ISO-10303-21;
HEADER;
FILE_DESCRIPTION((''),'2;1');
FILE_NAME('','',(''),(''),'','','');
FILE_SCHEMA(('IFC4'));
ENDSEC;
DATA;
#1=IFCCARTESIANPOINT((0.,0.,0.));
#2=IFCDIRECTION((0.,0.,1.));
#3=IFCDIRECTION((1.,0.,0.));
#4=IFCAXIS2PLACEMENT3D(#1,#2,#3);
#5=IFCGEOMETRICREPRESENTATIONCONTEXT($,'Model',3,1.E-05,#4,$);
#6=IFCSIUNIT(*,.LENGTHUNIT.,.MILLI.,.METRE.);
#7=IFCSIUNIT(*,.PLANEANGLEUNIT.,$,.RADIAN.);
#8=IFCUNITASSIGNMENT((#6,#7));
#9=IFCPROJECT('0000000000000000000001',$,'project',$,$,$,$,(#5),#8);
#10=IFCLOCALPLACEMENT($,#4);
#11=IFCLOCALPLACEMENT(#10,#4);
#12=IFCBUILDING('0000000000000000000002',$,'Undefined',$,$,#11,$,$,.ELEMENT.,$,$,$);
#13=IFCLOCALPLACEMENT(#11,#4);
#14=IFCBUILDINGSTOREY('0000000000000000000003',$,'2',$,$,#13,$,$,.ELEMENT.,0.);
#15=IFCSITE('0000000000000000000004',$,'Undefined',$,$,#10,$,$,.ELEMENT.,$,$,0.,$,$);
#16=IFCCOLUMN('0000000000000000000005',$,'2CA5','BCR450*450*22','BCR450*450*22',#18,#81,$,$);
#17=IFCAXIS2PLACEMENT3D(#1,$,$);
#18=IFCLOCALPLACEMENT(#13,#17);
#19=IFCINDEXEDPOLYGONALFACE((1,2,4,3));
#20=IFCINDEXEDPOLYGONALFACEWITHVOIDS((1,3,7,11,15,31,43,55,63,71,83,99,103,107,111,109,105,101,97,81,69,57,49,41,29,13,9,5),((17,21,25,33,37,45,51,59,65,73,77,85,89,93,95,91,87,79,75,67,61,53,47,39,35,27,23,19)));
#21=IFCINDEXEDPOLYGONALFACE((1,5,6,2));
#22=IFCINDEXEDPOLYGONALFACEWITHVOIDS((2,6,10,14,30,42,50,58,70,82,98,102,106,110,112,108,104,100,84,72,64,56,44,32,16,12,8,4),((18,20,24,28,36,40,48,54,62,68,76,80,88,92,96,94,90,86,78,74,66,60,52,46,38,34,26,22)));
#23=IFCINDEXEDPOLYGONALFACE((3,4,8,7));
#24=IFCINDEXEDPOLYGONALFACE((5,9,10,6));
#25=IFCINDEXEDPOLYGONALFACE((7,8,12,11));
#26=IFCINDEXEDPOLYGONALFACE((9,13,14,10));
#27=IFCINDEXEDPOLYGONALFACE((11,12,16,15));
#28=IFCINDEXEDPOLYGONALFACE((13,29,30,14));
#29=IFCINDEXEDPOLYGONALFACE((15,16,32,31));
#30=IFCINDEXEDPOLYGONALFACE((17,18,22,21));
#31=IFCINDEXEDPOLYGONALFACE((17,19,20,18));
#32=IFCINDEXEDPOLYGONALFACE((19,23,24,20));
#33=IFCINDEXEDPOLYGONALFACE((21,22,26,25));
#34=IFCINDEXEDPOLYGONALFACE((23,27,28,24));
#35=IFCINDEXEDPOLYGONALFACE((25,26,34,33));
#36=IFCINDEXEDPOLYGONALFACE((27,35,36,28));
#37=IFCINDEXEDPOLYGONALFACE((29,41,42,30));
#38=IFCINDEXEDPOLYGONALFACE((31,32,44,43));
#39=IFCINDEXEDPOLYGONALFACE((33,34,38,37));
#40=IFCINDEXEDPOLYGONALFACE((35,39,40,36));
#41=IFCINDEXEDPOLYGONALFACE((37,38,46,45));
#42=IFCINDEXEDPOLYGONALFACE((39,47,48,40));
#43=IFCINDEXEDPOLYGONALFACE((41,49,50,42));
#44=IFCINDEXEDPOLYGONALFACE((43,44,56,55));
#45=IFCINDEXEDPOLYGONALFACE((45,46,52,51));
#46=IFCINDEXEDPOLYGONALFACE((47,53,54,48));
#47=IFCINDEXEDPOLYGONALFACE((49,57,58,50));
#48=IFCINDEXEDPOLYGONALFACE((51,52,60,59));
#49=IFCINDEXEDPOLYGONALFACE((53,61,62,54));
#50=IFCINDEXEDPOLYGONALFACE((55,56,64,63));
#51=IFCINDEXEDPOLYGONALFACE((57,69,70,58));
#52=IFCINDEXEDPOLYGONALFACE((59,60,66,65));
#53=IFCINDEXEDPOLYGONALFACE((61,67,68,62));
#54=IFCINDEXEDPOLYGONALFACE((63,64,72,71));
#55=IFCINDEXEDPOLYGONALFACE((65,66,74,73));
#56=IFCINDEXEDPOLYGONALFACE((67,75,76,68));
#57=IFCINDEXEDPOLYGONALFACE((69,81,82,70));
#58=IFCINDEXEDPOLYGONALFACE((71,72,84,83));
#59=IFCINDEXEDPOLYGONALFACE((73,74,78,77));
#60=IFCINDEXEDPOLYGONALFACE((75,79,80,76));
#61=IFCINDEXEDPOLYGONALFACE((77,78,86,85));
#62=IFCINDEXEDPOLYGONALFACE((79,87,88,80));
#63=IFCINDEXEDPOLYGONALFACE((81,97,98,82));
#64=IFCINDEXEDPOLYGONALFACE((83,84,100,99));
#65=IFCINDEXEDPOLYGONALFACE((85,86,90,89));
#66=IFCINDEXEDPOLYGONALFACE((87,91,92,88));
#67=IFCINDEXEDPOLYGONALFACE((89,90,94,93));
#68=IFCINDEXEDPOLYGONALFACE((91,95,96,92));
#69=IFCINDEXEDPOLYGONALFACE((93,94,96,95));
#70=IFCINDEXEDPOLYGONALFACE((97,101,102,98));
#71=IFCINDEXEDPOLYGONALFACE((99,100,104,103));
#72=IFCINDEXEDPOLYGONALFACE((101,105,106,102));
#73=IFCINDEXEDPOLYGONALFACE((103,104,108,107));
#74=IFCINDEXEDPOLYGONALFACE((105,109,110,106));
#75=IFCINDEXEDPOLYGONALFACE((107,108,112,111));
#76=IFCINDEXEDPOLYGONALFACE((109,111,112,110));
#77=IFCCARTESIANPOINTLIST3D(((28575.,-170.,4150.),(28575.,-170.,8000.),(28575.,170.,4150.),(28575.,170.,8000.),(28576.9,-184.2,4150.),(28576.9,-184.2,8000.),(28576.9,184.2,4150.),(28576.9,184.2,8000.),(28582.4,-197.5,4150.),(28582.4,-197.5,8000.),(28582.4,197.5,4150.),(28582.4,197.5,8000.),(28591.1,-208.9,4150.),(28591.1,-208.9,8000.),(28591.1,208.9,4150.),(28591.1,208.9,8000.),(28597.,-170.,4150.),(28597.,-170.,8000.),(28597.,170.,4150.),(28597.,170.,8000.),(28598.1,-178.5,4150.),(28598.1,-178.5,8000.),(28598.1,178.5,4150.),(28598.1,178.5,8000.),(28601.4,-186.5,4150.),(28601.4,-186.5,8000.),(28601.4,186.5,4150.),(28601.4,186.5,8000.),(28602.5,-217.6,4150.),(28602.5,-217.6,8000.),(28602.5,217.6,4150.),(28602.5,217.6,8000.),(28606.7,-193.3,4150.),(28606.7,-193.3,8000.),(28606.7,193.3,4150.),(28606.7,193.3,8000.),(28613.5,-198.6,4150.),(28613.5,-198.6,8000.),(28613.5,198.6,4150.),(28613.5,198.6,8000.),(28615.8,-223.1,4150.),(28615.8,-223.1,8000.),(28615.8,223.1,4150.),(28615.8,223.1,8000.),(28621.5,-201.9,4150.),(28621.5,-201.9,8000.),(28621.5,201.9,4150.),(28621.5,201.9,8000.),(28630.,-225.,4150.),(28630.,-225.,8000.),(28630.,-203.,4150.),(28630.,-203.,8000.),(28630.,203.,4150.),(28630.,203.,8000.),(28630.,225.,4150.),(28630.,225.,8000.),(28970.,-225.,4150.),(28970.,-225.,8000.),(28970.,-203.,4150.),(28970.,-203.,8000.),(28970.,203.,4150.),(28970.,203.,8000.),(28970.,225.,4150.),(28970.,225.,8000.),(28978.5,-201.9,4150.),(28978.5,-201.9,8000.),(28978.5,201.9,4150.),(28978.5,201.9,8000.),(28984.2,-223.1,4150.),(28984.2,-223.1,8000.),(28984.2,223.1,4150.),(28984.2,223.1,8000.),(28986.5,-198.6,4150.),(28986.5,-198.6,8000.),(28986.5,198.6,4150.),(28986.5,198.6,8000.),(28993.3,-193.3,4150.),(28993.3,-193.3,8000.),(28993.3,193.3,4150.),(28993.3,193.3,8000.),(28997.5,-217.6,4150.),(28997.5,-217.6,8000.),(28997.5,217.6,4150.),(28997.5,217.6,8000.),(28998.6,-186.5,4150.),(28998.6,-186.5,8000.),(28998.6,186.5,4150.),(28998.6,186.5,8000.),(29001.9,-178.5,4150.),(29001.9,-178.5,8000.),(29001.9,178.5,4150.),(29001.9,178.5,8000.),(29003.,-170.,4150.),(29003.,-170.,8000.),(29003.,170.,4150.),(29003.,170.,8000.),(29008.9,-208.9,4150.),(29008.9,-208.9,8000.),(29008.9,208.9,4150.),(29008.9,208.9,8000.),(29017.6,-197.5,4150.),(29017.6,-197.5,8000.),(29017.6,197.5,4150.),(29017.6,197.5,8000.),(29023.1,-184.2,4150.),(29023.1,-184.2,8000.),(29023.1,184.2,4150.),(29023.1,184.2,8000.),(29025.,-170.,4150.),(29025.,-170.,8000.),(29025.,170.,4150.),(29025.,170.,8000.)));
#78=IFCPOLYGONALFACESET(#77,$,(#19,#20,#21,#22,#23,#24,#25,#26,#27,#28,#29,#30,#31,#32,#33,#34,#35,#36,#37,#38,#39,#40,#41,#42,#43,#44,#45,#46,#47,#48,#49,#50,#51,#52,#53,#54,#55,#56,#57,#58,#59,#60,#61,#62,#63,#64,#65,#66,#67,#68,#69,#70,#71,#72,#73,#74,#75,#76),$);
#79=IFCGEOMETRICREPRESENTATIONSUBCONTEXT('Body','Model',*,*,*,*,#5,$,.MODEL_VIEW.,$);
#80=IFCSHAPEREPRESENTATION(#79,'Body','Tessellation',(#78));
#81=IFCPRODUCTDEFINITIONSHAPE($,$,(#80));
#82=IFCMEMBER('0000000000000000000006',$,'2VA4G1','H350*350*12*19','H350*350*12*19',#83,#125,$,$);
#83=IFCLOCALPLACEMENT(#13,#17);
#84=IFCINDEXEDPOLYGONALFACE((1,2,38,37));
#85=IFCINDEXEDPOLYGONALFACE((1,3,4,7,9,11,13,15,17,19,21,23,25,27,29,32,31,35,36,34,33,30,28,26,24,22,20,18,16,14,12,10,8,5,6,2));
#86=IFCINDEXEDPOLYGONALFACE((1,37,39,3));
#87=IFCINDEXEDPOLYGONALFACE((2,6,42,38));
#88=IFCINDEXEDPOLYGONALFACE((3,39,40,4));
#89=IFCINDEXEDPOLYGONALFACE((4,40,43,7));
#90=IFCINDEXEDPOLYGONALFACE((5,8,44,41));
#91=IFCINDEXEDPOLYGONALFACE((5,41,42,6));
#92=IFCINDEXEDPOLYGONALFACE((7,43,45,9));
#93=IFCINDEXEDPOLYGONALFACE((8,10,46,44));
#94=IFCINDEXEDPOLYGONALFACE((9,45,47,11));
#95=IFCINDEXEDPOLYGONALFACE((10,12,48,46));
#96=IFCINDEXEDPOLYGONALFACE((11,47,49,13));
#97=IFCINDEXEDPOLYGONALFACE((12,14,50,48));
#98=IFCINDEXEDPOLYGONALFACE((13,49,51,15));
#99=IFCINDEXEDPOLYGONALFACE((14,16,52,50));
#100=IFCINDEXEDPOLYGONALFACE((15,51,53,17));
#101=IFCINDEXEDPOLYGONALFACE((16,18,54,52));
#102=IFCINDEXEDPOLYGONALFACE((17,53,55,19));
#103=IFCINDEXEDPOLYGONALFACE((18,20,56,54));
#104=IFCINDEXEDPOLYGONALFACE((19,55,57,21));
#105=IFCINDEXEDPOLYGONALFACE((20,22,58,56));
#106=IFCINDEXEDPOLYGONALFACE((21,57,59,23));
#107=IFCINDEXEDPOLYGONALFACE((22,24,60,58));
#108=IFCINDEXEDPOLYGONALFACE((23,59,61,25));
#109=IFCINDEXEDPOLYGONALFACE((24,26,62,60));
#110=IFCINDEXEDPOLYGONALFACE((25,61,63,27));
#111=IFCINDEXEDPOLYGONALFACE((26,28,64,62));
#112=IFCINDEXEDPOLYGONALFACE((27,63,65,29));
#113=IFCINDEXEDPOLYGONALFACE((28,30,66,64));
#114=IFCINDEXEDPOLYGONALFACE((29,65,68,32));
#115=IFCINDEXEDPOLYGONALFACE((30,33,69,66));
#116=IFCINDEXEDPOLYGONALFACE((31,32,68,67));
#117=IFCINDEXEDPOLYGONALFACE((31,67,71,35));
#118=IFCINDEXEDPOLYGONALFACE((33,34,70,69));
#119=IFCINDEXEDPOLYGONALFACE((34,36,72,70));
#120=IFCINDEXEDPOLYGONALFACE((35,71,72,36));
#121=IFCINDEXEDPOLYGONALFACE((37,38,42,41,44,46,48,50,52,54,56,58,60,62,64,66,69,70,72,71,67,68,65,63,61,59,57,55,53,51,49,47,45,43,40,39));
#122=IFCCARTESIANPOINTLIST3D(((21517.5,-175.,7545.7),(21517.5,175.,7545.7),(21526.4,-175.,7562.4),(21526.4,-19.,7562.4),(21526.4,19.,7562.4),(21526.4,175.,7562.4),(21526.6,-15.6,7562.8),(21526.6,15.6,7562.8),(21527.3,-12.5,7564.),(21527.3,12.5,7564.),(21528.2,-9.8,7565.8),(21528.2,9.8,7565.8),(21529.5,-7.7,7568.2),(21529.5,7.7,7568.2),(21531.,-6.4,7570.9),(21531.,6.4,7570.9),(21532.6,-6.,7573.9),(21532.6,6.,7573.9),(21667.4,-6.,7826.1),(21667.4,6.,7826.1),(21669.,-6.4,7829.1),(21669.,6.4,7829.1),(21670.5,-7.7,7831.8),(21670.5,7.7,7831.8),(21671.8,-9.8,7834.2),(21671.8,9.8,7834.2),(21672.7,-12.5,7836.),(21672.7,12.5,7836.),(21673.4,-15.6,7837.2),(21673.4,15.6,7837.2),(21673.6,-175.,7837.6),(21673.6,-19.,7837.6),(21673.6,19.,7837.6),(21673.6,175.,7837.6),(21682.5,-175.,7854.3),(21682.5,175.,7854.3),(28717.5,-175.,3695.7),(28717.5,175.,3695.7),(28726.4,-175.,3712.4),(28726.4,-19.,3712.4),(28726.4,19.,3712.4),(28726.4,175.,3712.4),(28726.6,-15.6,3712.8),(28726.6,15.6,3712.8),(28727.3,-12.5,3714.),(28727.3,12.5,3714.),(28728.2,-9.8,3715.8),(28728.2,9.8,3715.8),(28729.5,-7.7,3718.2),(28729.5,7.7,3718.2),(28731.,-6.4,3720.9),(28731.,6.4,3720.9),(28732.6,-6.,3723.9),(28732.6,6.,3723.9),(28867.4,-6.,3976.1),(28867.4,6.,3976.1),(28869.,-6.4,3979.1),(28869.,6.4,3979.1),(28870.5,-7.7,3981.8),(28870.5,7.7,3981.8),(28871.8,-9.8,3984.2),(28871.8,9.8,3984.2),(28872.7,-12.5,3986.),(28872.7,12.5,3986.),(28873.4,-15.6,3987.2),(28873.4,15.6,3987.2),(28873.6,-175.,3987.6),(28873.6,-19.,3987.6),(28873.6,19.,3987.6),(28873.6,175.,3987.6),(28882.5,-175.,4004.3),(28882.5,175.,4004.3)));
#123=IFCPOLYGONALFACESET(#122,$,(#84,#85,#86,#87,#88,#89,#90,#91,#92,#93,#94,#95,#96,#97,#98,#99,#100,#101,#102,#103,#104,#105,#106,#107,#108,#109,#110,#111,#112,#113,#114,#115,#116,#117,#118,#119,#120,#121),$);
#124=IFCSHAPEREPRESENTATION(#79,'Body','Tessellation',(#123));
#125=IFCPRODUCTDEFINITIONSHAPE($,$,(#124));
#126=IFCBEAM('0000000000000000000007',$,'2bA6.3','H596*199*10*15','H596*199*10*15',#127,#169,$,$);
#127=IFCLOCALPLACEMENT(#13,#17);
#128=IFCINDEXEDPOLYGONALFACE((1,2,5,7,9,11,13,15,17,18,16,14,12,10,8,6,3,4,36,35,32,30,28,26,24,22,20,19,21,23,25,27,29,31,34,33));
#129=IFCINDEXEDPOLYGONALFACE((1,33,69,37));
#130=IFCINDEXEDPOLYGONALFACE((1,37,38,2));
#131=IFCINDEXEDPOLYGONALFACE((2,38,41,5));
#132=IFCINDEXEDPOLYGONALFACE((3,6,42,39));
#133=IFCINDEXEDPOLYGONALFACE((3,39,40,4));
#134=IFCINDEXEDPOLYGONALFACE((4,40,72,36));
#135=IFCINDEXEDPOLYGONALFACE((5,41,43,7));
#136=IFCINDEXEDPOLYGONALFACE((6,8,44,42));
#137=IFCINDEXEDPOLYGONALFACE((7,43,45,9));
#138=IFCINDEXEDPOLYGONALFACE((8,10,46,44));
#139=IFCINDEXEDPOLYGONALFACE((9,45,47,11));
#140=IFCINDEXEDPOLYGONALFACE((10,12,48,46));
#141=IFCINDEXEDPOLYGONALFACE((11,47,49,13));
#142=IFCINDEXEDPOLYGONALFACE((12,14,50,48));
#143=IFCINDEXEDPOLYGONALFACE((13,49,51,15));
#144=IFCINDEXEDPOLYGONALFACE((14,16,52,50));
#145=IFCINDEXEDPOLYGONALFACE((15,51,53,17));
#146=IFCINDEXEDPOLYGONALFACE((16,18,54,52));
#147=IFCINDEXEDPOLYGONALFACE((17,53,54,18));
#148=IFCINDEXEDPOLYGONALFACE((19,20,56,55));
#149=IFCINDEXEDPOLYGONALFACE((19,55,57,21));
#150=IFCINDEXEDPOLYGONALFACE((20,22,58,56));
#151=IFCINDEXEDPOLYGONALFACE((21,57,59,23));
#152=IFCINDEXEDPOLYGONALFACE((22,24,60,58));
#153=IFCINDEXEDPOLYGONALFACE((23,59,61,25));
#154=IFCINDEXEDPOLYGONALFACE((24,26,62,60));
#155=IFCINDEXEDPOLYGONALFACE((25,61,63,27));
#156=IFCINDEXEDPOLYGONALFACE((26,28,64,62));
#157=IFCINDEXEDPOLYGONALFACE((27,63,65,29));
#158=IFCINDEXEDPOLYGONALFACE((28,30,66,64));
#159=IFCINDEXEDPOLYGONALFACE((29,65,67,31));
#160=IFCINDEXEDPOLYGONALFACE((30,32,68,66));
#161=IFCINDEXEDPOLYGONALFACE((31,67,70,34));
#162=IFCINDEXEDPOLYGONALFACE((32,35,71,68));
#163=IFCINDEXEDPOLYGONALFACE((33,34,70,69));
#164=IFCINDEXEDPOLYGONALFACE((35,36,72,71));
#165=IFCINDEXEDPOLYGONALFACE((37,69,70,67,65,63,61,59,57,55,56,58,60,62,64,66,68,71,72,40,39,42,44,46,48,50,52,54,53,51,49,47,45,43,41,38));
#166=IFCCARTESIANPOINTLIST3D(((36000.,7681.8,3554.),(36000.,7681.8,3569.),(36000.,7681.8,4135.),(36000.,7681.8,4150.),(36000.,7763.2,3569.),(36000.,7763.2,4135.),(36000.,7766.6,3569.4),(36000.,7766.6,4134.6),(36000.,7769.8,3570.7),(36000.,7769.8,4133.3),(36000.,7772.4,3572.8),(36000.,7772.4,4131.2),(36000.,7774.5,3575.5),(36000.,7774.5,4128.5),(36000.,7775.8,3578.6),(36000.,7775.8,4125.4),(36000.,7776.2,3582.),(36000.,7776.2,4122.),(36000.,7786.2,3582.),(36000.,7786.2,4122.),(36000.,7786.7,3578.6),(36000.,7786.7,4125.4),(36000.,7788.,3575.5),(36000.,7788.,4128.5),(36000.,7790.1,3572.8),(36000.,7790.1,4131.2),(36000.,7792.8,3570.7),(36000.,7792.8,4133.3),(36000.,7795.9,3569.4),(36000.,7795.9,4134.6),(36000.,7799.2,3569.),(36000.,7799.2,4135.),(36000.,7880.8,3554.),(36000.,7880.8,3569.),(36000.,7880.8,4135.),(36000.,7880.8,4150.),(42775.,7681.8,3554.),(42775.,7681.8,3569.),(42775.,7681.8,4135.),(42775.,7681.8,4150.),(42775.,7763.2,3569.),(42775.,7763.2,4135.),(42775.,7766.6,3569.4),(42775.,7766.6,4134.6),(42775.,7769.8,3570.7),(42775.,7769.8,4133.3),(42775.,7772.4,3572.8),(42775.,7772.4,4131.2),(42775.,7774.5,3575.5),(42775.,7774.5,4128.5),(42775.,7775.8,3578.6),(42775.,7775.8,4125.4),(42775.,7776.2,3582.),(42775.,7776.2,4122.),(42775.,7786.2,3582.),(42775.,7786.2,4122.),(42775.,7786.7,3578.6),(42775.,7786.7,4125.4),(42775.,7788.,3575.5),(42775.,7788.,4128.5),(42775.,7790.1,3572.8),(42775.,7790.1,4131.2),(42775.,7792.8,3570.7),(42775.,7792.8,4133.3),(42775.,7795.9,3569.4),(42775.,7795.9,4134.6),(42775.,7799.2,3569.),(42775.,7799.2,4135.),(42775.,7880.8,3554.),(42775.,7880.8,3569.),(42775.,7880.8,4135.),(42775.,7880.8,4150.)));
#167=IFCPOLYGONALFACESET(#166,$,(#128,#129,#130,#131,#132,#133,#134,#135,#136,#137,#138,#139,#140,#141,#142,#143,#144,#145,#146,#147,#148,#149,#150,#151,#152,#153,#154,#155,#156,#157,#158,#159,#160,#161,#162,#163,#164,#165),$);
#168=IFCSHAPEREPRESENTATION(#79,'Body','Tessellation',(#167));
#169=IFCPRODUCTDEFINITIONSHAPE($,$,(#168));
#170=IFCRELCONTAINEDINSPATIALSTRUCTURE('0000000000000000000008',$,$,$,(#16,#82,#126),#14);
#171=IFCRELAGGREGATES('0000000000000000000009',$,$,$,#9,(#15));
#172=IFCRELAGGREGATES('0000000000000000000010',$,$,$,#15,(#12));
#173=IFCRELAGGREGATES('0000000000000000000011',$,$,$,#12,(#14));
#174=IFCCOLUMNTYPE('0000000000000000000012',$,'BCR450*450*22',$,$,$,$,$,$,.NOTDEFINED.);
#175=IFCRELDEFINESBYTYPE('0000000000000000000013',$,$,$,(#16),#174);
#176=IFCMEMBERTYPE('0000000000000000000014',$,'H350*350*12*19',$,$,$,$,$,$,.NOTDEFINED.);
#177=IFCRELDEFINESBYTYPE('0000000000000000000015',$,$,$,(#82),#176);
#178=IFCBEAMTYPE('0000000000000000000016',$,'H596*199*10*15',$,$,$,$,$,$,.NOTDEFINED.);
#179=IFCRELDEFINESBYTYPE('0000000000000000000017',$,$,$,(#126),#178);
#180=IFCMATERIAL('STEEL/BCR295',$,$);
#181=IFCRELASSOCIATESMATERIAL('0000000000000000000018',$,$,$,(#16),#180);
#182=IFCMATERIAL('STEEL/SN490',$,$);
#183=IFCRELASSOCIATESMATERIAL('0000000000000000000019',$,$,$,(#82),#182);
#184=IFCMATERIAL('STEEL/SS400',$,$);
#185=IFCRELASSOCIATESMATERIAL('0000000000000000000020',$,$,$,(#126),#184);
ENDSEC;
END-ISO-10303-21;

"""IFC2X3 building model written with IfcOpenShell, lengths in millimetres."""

from ifc_helpers import new_model, si_unit, frame, origin_with_axes, origin_2d_with_axis, place, context, subcontext, project, spatial, hollow_rectangle, i_section, extrude, material, type_object, element, save


model = new_model("IFC2X3")

# Units and contexts
model_context = context("Model", 3, precision=1e-05, world=origin_with_axes())
body_context = subcontext(model_context, "Body", "Model", "MODEL_VIEW")
ifc_project = project(units=[si_unit("LENGTHUNIT", "METRE", prefix="MILLI"), si_unit("PLANEANGLEUNIT", "RADIAN")], contexts=[model_context])

# Site, building, storey
site_placement = place(None, origin_with_axes())
site = spatial("IfcSite", under=ifc_project, at=site_placement, Name="Undefined", CompositionType="ELEMENT", RefElevation=0.0)
building_placement = place(site_placement, origin_with_axes())
building = spatial("IfcBuilding", under=site, at=building_placement, Name="Undefined", CompositionType="ELEMENT")
storey_placement = place(building_placement, origin_with_axes())
storey = spatial("IfcBuildingStorey", under=building, at=storey_placement, Name="2", CompositionType="ELEMENT", Elevation=0.0)

# Column
ifc_material_1 = material(Name="STEEL/SN490")
ifc_material_2 = material(Name="STEEL/BCR295")
column_type_1 = type_object("IfcColumnType", Name="BCR450*450*22", PredefinedType="NOTDEFINED")
for number, where, z_axis, x_axis, name in (
    (1, (28800.0, 0.0, 4150.0), (0.0, 0.0, 1.0), (0.0, 1.0, 0.0), "2CA5"),
):
    element("IfcColumn", number, at=place(storey_placement, frame(where, z_axis=z_axis, x_axis=x_axis)), inside=storey, type_object=column_type_1, material=ifc_material_2, Name=name, Description="BCR450*450*22", ObjectType="BCR450*450*22", context=body_context, shape_type="SweptSolid", body=[
        extrude(hollow_rectangle(XDim=450.0, YDim=450.0, WallThickness=22.0, InnerFilletRadius=33.0, OuterFilletRadius=55.0, at=origin_2d_with_axis()), frame((0.0, 0.0, 3850.0), z_axis=(0.0, 0.0, -1.0), x_axis=(0.0, 1.0, 0.0)), (0.0, 0.0, 1.0), 3850.0),
    ])

# Member
member_type = type_object("IfcMemberType", Name="H350*350*12*19", PredefinedType="NOTDEFINED")
member_placement = place(storey_placement, frame((28800.0, 0.0, 3850.0), z_axis=(0.471542, 0.0, 0.881844), x_axis=(-0.881844, 0.0, 0.471542)))
element("IfcMember", 2, at=member_placement, inside=storey, type_object=member_type, material=ifc_material_1, Name="2VA4G1", Description="H350*350*12*19", ObjectType="H350*350*12*19", context=body_context, shape_type="SweptSolid", body=[
    extrude(i_section(OverallWidth=350.0, OverallDepth=350.0, WebThickness=12.0, FlangeThickness=19.0, FilletRadius=13.0, at=origin_2d_with_axis()), frame((8164.7, 0.0, 0.0), z_axis=(-1.0, 0.0, 0.0), x_axis=(0.0, -1.0, 0.0)), (0.0, 0.0, 1.0), 8164.7),
])

# Beam
ifc_material_3 = material(Name="STEEL/SS400")
beam_type_1 = type_object("IfcBeamType", Name="H596*199*10*15", PredefinedType="NOTDEFINED")
for number, where, z_axis, x_axis, name in (
    (3, (36000.0, 7781.2, 3852.0), (0.0, 0.0, 1.0), (1.0, 0.0, 0.0), "2bA6.3"),
):
    element("IfcBeam", number, at=place(storey_placement, frame(where, z_axis=z_axis, x_axis=x_axis)), inside=storey, type_object=beam_type_1, material=ifc_material_3, Name=name, Description="H596*199*10*15", ObjectType="H596*199*10*15", context=body_context, shape_type="SweptSolid", body=[
        extrude(i_section(OverallWidth=199.0, OverallDepth=596.0, WebThickness=10.0, FlangeThickness=15.0, FilletRadius=13.0, at=origin_2d_with_axis()), frame((6775.0, 0.0, 0.0), z_axis=(-1.0, 0.0, 0.0), x_axis=(0.0, -1.0, 0.0)), (0.0, 0.0, 1.0), 6775.0),
    ])

save(model, "model.ifc")
